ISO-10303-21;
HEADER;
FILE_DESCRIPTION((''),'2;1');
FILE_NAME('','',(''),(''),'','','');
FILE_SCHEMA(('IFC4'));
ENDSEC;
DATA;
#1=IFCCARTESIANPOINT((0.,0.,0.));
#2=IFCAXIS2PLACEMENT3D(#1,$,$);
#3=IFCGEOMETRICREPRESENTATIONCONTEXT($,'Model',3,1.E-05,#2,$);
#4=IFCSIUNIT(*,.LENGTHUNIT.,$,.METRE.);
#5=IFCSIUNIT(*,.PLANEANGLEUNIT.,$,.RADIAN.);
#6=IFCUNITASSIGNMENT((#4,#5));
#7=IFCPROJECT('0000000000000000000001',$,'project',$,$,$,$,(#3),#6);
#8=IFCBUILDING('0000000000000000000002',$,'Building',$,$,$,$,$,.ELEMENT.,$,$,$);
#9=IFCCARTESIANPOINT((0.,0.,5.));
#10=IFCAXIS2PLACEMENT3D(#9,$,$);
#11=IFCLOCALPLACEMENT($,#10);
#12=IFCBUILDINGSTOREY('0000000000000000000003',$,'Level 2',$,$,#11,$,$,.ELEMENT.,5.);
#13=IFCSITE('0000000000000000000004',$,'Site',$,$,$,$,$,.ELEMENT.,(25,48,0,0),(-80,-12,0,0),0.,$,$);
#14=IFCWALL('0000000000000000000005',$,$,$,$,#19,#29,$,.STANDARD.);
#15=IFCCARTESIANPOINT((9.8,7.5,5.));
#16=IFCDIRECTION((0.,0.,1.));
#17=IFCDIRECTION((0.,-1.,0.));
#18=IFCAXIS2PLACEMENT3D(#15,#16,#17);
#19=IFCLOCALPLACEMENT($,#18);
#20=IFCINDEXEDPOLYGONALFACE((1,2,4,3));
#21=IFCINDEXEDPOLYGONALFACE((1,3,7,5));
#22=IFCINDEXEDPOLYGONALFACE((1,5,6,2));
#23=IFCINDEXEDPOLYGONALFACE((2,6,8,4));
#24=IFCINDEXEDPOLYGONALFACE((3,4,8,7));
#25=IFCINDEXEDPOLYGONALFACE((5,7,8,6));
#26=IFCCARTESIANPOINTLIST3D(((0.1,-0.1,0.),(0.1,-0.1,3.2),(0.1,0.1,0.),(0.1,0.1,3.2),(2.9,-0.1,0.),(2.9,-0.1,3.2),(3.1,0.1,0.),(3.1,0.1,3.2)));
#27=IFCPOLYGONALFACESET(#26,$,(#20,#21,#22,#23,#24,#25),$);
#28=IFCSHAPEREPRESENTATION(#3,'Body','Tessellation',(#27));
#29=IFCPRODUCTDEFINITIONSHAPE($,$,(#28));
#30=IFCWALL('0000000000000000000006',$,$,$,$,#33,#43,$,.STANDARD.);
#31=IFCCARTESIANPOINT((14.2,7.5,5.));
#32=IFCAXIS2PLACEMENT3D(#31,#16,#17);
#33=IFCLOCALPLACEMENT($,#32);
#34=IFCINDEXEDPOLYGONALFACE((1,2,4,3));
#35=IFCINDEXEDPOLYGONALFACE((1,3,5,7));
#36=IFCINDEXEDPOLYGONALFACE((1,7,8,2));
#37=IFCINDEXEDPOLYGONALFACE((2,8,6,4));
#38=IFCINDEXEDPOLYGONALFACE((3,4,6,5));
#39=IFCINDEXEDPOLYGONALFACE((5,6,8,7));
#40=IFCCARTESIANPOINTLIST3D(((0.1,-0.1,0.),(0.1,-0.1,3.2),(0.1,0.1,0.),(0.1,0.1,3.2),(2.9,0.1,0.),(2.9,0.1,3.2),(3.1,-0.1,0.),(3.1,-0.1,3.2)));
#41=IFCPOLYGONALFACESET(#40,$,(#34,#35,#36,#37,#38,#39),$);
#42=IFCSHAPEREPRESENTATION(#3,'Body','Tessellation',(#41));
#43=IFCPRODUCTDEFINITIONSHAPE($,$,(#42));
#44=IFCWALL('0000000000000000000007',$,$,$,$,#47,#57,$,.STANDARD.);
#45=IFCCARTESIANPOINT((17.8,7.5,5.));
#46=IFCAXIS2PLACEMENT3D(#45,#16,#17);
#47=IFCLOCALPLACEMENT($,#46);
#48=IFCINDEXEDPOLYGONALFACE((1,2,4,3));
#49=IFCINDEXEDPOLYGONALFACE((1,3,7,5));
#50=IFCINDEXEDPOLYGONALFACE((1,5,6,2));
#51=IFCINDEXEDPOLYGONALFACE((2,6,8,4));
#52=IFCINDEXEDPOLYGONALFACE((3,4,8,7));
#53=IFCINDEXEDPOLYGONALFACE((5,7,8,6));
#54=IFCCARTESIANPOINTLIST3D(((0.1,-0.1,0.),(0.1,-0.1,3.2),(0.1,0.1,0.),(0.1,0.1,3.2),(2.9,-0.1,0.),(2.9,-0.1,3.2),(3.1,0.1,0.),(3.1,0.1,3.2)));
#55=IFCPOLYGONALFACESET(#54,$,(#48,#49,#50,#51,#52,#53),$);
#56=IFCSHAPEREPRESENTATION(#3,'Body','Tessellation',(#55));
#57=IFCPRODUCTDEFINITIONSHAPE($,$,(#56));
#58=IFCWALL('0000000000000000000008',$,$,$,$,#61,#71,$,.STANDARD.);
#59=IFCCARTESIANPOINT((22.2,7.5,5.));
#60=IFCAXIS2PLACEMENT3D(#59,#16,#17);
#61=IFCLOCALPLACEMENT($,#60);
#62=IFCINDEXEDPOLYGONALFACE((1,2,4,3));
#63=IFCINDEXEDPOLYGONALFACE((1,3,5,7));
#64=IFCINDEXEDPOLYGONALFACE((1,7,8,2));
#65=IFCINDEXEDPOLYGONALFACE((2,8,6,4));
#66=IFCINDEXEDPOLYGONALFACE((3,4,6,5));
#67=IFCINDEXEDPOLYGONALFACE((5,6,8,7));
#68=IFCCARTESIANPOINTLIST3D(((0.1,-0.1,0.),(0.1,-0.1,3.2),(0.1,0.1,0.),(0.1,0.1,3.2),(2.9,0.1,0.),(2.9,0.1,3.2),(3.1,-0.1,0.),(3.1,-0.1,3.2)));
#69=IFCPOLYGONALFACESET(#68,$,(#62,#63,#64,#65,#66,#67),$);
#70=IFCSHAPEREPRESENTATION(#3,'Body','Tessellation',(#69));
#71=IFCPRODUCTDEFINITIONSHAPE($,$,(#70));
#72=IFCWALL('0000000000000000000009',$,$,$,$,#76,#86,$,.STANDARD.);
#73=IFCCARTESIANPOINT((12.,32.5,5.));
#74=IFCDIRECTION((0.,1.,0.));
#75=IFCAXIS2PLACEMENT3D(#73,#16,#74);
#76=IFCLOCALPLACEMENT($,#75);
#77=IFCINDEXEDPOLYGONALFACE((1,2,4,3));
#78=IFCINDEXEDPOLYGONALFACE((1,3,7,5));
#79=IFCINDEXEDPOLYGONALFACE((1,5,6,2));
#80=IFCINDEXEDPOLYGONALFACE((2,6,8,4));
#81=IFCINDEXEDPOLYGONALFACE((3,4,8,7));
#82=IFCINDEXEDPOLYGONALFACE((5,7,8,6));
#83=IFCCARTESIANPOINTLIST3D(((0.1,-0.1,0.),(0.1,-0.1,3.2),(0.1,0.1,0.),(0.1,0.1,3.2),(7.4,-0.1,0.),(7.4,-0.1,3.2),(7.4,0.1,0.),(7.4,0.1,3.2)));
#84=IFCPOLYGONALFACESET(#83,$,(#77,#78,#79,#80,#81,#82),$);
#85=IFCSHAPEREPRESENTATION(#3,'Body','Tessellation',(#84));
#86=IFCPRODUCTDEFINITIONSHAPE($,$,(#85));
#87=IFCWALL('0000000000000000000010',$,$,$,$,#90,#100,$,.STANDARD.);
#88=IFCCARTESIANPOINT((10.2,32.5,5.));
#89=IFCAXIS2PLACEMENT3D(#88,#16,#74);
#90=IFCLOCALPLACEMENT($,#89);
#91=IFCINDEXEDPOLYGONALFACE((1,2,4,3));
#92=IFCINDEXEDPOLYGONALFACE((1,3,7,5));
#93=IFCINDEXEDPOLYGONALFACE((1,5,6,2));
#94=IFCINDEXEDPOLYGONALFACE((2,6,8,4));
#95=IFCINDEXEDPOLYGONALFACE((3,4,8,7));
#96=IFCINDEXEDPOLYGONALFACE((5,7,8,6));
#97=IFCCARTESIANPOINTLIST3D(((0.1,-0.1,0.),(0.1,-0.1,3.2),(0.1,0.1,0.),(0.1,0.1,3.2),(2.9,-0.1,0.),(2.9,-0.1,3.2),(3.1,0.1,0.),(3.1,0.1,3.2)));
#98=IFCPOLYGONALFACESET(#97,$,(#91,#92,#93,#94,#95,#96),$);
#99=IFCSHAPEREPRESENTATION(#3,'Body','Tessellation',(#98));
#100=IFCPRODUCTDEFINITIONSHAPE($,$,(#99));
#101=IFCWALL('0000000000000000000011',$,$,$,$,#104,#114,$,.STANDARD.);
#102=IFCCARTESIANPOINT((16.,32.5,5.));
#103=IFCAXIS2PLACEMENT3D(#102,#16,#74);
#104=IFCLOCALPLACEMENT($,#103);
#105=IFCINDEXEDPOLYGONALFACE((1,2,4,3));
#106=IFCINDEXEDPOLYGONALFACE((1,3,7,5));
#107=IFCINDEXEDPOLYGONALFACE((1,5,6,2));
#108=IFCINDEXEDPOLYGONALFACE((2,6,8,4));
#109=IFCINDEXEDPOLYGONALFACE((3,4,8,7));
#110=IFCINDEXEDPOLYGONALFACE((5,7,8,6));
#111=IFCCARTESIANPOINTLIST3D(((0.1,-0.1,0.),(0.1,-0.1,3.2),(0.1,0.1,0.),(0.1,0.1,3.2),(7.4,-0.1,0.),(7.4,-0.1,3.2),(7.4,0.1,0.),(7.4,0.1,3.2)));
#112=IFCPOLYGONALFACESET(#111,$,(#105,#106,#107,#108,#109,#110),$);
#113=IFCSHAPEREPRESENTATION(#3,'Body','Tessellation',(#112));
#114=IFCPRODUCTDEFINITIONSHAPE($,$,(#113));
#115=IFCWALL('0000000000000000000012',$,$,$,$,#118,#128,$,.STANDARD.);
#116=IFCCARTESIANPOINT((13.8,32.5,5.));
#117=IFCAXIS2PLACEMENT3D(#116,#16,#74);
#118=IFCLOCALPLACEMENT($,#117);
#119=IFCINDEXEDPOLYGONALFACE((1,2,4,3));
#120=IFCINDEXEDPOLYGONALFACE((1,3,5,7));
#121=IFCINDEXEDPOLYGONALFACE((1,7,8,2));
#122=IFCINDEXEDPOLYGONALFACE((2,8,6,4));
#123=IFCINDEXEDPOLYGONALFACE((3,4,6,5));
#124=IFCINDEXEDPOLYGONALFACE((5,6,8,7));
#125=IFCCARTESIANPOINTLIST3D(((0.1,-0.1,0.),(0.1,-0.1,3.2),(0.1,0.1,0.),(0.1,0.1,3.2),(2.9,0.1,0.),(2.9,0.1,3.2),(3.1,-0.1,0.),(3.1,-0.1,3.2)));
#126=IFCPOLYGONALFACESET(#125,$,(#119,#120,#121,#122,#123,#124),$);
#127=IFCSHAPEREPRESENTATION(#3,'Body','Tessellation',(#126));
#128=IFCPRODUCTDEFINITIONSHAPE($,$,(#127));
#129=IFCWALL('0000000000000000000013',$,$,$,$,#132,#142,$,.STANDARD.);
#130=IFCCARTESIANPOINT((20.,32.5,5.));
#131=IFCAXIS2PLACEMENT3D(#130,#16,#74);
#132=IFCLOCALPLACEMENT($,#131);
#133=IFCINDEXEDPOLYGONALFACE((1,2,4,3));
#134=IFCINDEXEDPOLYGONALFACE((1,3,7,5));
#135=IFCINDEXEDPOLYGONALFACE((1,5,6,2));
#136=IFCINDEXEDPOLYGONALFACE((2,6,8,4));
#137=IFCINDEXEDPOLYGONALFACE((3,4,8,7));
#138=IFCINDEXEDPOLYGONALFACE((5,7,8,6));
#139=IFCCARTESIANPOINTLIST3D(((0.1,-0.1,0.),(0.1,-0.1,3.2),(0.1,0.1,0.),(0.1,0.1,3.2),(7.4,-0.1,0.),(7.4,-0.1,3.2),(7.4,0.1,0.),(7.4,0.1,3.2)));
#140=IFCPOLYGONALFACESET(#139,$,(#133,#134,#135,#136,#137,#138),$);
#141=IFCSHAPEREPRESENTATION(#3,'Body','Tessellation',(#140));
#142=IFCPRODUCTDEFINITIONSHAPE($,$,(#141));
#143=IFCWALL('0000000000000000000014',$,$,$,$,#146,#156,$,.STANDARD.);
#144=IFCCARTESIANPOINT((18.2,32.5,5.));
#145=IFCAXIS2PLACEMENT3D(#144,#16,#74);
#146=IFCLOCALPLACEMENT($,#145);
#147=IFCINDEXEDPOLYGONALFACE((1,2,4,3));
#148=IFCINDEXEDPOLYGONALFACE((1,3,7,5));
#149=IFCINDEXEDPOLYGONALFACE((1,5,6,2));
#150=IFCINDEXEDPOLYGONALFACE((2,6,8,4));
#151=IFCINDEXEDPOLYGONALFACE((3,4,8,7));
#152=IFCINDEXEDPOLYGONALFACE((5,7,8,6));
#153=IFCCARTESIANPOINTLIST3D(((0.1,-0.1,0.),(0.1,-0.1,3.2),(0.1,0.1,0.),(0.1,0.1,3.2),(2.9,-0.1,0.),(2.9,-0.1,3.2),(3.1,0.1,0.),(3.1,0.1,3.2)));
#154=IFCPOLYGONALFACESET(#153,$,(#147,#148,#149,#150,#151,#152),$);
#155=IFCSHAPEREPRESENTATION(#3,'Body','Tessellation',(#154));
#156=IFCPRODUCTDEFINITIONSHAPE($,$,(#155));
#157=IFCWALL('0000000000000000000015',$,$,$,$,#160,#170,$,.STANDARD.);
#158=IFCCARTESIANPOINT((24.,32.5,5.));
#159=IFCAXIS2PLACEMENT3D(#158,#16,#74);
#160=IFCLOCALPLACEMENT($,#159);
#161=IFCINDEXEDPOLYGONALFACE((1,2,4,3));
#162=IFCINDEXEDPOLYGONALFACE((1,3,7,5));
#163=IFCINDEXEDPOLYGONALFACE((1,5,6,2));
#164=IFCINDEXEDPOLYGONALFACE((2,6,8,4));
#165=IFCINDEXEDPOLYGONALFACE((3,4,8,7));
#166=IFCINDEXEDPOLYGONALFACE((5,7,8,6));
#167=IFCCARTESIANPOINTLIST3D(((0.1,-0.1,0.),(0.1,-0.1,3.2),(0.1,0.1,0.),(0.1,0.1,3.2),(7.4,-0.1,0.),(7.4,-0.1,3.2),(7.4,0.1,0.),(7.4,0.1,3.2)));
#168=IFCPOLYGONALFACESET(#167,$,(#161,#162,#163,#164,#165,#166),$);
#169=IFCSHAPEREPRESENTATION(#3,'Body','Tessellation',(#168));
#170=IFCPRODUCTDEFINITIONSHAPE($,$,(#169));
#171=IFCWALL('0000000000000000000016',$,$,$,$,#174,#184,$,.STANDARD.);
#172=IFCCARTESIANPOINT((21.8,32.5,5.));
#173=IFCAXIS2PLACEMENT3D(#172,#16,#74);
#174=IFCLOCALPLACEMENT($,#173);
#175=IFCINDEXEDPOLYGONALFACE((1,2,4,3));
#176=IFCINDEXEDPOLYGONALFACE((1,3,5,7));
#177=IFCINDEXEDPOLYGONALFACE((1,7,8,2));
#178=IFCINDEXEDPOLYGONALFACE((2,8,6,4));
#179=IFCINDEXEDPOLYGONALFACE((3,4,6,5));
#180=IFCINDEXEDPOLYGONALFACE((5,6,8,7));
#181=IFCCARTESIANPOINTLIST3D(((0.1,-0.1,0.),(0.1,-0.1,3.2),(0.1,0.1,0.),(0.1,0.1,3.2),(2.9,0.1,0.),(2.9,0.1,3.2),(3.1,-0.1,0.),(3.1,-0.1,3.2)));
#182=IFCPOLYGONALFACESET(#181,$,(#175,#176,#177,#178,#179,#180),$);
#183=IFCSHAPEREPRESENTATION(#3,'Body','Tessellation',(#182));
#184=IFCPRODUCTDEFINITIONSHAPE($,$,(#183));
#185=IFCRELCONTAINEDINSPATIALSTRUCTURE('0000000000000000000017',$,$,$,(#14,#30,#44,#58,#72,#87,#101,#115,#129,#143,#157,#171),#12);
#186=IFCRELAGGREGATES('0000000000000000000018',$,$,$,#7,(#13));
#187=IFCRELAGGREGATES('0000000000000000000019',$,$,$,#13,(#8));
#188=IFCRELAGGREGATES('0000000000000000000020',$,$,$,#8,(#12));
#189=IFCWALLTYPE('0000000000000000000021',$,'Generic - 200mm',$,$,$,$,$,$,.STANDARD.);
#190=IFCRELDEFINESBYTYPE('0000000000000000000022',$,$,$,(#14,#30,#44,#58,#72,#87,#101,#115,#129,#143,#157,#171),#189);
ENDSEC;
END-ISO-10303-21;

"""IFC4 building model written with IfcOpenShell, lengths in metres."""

from ifc_helpers import new_model, si_unit, frame, origin, place, context, project, spatial, polyline, outline, extrude, type_object, element, save


model = new_model("IFC4")

# Units and contexts
model_context = context("Model", 3, precision=1e-05, world=origin())
ifc_project = project(units=[si_unit("LENGTHUNIT", "METRE"), si_unit("PLANEANGLEUNIT", "RADIAN")], contexts=[model_context])

# Site, building, storey
site = spatial("IfcSite", under=ifc_project, Name="Site", CompositionType="ELEMENT", RefLatitude=(25, 48, 0, 0), RefLongitude=(-80, -12, 0, 0), RefElevation=0.0)
building = spatial("IfcBuilding", under=site, Name="Building", CompositionType="ELEMENT")
storey_placement = place(None, frame((0.0, 0.0, 5.0)))
storey = spatial("IfcBuildingStorey", under=building, at=storey_placement, Name="Level 2", CompositionType="ELEMENT", Elevation=5.0)

# Shared definitions
wall_type = type_object("IfcWallType", Name="Generic - 200mm", PredefinedType="STANDARD")

# Walls
wall_1_placement = place(None, frame((9.8, 7.5, 5.0), z_axis=(0.0, 0.0, 1.0), x_axis=(0.0, -1.0, 0.0)))
element("IfcWall", 1, at=wall_1_placement, inside=storey, type_object=wall_type, PredefinedType="STANDARD", context=model_context, shape_type="SweptSolid", body=[
    extrude(outline(polyline([(0.1, -0.1), (2.9, -0.1), (3.1, 0.1), (0.1, 0.1), (0.1, -0.1)])), origin(), (0.0, 0.0, 1.0), 3.2),
])
wall_2_placement = place(None, frame((14.2, 7.5, 5.0), z_axis=(0.0, 0.0, 1.0), x_axis=(0.0, -1.0, 0.0)))
element("IfcWall", 2, at=wall_2_placement, inside=storey, type_object=wall_type, PredefinedType="STANDARD", context=model_context, shape_type="SweptSolid", body=[
    extrude(outline(polyline([(0.1, -0.1), (3.1, -0.1), (2.9, 0.1), (0.1, 0.1), (0.1, -0.1)])), origin(), (0.0, 0.0, 1.0), 3.2),
])
wall_3_placement = place(None, frame((17.8, 7.5, 5.0), z_axis=(0.0, 0.0, 1.0), x_axis=(0.0, -1.0, 0.0)))
element("IfcWall", 3, at=wall_3_placement, inside=storey, type_object=wall_type, PredefinedType="STANDARD", context=model_context, shape_type="SweptSolid", body=[
    extrude(outline(polyline([(0.1, -0.1), (2.9, -0.1), (3.1, 0.1), (0.1, 0.1), (0.1, -0.1)])), origin(), (0.0, 0.0, 1.0), 3.2),
])
wall_4_placement = place(None, frame((22.2, 7.5, 5.0), z_axis=(0.0, 0.0, 1.0), x_axis=(0.0, -1.0, 0.0)))
element("IfcWall", 4, at=wall_4_placement, inside=storey, type_object=wall_type, PredefinedType="STANDARD", context=model_context, shape_type="SweptSolid", body=[
    extrude(outline(polyline([(0.1, -0.1), (3.1, -0.1), (2.9, 0.1), (0.1, 0.1), (0.1, -0.1)])), origin(), (0.0, 0.0, 1.0), 3.2),
])
wall_5_placement = place(None, frame((12.0, 32.5, 5.0), z_axis=(0.0, 0.0, 1.0), x_axis=(0.0, 1.0, 0.0)))
element("IfcWall", 5, at=wall_5_placement, inside=storey, type_object=wall_type, PredefinedType="STANDARD", context=model_context, shape_type="SweptSolid", body=[
    extrude(outline(polyline([(0.1, -0.1), (7.4, -0.1), (7.4, 0.1), (0.1, 0.1), (0.1, -0.1)])), origin(), (0.0, 0.0, 1.0), 3.2),
])
wall_6_placement = place(None, frame((10.2, 32.5, 5.0), z_axis=(0.0, 0.0, 1.0), x_axis=(0.0, 1.0, 0.0)))
element("IfcWall", 6, at=wall_6_placement, inside=storey, type_object=wall_type, PredefinedType="STANDARD", context=model_context, shape_type="SweptSolid", body=[
    extrude(outline(polyline([(0.1, -0.1), (2.9, -0.1), (3.1, 0.1), (0.1, 0.1), (0.1, -0.1)])), origin(), (0.0, 0.0, 1.0), 3.2),
])
wall_7_placement = place(None, frame((16.0, 32.5, 5.0), z_axis=(0.0, 0.0, 1.0), x_axis=(0.0, 1.0, 0.0)))
element("IfcWall", 7, at=wall_7_placement, inside=storey, type_object=wall_type, PredefinedType="STANDARD", context=model_context, shape_type="SweptSolid", body=[
    extrude(outline(polyline([(0.1, -0.1), (7.4, -0.1), (7.4, 0.1), (0.1, 0.1), (0.1, -0.1)])), origin(), (0.0, 0.0, 1.0), 3.2),
])
wall_8_placement = place(None, frame((13.8, 32.5, 5.0), z_axis=(0.0, 0.0, 1.0), x_axis=(0.0, 1.0, 0.0)))
element("IfcWall", 8, at=wall_8_placement, inside=storey, type_object=wall_type, PredefinedType="STANDARD", context=model_context, shape_type="SweptSolid", body=[
    extrude(outline(polyline([(0.1, -0.1), (3.1, -0.1), (2.9, 0.1), (0.1, 0.1), (0.1, -0.1)])), origin(), (0.0, 0.0, 1.0), 3.2),
])
wall_9_placement = place(None, frame((20.0, 32.5, 5.0), z_axis=(0.0, 0.0, 1.0), x_axis=(0.0, 1.0, 0.0)))
element("IfcWall", 9, at=wall_9_placement, inside=storey, type_object=wall_type, PredefinedType="STANDARD", context=model_context, shape_type="SweptSolid", body=[
    extrude(outline(polyline([(0.1, -0.1), (7.4, -0.1), (7.4, 0.1), (0.1, 0.1), (0.1, -0.1)])), origin(), (0.0, 0.0, 1.0), 3.2),
])
wall_10_placement = place(None, frame((18.2, 32.5, 5.0), z_axis=(0.0, 0.0, 1.0), x_axis=(0.0, 1.0, 0.0)))
element("IfcWall", 10, at=wall_10_placement, inside=storey, type_object=wall_type, PredefinedType="STANDARD", context=model_context, shape_type="SweptSolid", body=[
    extrude(outline(polyline([(0.1, -0.1), (2.9, -0.1), (3.1, 0.1), (0.1, 0.1), (0.1, -0.1)])), origin(), (0.0, 0.0, 1.0), 3.2),
])
wall_11_placement = place(None, frame((24.0, 32.5, 5.0), z_axis=(0.0, 0.0, 1.0), x_axis=(0.0, 1.0, 0.0)))
element("IfcWall", 11, at=wall_11_placement, inside=storey, type_object=wall_type, PredefinedType="STANDARD", context=model_context, shape_type="SweptSolid", body=[
    extrude(outline(polyline([(0.1, -0.1), (7.4, -0.1), (7.4, 0.1), (0.1, 0.1), (0.1, -0.1)])), origin(), (0.0, 0.0, 1.0), 3.2),
])
wall_12_placement = place(None, frame((21.8, 32.5, 5.0), z_axis=(0.0, 0.0, 1.0), x_axis=(0.0, 1.0, 0.0)))
element("IfcWall", 12, at=wall_12_placement, inside=storey, type_object=wall_type, PredefinedType="STANDARD", context=model_context, shape_type="SweptSolid", body=[
    extrude(outline(polyline([(0.1, -0.1), (3.1, -0.1), (2.9, 0.1), (0.1, 0.1), (0.1, -0.1)])), origin(), (0.0, 0.0, 1.0), 3.2),
])

save(model, "model.ifc")
